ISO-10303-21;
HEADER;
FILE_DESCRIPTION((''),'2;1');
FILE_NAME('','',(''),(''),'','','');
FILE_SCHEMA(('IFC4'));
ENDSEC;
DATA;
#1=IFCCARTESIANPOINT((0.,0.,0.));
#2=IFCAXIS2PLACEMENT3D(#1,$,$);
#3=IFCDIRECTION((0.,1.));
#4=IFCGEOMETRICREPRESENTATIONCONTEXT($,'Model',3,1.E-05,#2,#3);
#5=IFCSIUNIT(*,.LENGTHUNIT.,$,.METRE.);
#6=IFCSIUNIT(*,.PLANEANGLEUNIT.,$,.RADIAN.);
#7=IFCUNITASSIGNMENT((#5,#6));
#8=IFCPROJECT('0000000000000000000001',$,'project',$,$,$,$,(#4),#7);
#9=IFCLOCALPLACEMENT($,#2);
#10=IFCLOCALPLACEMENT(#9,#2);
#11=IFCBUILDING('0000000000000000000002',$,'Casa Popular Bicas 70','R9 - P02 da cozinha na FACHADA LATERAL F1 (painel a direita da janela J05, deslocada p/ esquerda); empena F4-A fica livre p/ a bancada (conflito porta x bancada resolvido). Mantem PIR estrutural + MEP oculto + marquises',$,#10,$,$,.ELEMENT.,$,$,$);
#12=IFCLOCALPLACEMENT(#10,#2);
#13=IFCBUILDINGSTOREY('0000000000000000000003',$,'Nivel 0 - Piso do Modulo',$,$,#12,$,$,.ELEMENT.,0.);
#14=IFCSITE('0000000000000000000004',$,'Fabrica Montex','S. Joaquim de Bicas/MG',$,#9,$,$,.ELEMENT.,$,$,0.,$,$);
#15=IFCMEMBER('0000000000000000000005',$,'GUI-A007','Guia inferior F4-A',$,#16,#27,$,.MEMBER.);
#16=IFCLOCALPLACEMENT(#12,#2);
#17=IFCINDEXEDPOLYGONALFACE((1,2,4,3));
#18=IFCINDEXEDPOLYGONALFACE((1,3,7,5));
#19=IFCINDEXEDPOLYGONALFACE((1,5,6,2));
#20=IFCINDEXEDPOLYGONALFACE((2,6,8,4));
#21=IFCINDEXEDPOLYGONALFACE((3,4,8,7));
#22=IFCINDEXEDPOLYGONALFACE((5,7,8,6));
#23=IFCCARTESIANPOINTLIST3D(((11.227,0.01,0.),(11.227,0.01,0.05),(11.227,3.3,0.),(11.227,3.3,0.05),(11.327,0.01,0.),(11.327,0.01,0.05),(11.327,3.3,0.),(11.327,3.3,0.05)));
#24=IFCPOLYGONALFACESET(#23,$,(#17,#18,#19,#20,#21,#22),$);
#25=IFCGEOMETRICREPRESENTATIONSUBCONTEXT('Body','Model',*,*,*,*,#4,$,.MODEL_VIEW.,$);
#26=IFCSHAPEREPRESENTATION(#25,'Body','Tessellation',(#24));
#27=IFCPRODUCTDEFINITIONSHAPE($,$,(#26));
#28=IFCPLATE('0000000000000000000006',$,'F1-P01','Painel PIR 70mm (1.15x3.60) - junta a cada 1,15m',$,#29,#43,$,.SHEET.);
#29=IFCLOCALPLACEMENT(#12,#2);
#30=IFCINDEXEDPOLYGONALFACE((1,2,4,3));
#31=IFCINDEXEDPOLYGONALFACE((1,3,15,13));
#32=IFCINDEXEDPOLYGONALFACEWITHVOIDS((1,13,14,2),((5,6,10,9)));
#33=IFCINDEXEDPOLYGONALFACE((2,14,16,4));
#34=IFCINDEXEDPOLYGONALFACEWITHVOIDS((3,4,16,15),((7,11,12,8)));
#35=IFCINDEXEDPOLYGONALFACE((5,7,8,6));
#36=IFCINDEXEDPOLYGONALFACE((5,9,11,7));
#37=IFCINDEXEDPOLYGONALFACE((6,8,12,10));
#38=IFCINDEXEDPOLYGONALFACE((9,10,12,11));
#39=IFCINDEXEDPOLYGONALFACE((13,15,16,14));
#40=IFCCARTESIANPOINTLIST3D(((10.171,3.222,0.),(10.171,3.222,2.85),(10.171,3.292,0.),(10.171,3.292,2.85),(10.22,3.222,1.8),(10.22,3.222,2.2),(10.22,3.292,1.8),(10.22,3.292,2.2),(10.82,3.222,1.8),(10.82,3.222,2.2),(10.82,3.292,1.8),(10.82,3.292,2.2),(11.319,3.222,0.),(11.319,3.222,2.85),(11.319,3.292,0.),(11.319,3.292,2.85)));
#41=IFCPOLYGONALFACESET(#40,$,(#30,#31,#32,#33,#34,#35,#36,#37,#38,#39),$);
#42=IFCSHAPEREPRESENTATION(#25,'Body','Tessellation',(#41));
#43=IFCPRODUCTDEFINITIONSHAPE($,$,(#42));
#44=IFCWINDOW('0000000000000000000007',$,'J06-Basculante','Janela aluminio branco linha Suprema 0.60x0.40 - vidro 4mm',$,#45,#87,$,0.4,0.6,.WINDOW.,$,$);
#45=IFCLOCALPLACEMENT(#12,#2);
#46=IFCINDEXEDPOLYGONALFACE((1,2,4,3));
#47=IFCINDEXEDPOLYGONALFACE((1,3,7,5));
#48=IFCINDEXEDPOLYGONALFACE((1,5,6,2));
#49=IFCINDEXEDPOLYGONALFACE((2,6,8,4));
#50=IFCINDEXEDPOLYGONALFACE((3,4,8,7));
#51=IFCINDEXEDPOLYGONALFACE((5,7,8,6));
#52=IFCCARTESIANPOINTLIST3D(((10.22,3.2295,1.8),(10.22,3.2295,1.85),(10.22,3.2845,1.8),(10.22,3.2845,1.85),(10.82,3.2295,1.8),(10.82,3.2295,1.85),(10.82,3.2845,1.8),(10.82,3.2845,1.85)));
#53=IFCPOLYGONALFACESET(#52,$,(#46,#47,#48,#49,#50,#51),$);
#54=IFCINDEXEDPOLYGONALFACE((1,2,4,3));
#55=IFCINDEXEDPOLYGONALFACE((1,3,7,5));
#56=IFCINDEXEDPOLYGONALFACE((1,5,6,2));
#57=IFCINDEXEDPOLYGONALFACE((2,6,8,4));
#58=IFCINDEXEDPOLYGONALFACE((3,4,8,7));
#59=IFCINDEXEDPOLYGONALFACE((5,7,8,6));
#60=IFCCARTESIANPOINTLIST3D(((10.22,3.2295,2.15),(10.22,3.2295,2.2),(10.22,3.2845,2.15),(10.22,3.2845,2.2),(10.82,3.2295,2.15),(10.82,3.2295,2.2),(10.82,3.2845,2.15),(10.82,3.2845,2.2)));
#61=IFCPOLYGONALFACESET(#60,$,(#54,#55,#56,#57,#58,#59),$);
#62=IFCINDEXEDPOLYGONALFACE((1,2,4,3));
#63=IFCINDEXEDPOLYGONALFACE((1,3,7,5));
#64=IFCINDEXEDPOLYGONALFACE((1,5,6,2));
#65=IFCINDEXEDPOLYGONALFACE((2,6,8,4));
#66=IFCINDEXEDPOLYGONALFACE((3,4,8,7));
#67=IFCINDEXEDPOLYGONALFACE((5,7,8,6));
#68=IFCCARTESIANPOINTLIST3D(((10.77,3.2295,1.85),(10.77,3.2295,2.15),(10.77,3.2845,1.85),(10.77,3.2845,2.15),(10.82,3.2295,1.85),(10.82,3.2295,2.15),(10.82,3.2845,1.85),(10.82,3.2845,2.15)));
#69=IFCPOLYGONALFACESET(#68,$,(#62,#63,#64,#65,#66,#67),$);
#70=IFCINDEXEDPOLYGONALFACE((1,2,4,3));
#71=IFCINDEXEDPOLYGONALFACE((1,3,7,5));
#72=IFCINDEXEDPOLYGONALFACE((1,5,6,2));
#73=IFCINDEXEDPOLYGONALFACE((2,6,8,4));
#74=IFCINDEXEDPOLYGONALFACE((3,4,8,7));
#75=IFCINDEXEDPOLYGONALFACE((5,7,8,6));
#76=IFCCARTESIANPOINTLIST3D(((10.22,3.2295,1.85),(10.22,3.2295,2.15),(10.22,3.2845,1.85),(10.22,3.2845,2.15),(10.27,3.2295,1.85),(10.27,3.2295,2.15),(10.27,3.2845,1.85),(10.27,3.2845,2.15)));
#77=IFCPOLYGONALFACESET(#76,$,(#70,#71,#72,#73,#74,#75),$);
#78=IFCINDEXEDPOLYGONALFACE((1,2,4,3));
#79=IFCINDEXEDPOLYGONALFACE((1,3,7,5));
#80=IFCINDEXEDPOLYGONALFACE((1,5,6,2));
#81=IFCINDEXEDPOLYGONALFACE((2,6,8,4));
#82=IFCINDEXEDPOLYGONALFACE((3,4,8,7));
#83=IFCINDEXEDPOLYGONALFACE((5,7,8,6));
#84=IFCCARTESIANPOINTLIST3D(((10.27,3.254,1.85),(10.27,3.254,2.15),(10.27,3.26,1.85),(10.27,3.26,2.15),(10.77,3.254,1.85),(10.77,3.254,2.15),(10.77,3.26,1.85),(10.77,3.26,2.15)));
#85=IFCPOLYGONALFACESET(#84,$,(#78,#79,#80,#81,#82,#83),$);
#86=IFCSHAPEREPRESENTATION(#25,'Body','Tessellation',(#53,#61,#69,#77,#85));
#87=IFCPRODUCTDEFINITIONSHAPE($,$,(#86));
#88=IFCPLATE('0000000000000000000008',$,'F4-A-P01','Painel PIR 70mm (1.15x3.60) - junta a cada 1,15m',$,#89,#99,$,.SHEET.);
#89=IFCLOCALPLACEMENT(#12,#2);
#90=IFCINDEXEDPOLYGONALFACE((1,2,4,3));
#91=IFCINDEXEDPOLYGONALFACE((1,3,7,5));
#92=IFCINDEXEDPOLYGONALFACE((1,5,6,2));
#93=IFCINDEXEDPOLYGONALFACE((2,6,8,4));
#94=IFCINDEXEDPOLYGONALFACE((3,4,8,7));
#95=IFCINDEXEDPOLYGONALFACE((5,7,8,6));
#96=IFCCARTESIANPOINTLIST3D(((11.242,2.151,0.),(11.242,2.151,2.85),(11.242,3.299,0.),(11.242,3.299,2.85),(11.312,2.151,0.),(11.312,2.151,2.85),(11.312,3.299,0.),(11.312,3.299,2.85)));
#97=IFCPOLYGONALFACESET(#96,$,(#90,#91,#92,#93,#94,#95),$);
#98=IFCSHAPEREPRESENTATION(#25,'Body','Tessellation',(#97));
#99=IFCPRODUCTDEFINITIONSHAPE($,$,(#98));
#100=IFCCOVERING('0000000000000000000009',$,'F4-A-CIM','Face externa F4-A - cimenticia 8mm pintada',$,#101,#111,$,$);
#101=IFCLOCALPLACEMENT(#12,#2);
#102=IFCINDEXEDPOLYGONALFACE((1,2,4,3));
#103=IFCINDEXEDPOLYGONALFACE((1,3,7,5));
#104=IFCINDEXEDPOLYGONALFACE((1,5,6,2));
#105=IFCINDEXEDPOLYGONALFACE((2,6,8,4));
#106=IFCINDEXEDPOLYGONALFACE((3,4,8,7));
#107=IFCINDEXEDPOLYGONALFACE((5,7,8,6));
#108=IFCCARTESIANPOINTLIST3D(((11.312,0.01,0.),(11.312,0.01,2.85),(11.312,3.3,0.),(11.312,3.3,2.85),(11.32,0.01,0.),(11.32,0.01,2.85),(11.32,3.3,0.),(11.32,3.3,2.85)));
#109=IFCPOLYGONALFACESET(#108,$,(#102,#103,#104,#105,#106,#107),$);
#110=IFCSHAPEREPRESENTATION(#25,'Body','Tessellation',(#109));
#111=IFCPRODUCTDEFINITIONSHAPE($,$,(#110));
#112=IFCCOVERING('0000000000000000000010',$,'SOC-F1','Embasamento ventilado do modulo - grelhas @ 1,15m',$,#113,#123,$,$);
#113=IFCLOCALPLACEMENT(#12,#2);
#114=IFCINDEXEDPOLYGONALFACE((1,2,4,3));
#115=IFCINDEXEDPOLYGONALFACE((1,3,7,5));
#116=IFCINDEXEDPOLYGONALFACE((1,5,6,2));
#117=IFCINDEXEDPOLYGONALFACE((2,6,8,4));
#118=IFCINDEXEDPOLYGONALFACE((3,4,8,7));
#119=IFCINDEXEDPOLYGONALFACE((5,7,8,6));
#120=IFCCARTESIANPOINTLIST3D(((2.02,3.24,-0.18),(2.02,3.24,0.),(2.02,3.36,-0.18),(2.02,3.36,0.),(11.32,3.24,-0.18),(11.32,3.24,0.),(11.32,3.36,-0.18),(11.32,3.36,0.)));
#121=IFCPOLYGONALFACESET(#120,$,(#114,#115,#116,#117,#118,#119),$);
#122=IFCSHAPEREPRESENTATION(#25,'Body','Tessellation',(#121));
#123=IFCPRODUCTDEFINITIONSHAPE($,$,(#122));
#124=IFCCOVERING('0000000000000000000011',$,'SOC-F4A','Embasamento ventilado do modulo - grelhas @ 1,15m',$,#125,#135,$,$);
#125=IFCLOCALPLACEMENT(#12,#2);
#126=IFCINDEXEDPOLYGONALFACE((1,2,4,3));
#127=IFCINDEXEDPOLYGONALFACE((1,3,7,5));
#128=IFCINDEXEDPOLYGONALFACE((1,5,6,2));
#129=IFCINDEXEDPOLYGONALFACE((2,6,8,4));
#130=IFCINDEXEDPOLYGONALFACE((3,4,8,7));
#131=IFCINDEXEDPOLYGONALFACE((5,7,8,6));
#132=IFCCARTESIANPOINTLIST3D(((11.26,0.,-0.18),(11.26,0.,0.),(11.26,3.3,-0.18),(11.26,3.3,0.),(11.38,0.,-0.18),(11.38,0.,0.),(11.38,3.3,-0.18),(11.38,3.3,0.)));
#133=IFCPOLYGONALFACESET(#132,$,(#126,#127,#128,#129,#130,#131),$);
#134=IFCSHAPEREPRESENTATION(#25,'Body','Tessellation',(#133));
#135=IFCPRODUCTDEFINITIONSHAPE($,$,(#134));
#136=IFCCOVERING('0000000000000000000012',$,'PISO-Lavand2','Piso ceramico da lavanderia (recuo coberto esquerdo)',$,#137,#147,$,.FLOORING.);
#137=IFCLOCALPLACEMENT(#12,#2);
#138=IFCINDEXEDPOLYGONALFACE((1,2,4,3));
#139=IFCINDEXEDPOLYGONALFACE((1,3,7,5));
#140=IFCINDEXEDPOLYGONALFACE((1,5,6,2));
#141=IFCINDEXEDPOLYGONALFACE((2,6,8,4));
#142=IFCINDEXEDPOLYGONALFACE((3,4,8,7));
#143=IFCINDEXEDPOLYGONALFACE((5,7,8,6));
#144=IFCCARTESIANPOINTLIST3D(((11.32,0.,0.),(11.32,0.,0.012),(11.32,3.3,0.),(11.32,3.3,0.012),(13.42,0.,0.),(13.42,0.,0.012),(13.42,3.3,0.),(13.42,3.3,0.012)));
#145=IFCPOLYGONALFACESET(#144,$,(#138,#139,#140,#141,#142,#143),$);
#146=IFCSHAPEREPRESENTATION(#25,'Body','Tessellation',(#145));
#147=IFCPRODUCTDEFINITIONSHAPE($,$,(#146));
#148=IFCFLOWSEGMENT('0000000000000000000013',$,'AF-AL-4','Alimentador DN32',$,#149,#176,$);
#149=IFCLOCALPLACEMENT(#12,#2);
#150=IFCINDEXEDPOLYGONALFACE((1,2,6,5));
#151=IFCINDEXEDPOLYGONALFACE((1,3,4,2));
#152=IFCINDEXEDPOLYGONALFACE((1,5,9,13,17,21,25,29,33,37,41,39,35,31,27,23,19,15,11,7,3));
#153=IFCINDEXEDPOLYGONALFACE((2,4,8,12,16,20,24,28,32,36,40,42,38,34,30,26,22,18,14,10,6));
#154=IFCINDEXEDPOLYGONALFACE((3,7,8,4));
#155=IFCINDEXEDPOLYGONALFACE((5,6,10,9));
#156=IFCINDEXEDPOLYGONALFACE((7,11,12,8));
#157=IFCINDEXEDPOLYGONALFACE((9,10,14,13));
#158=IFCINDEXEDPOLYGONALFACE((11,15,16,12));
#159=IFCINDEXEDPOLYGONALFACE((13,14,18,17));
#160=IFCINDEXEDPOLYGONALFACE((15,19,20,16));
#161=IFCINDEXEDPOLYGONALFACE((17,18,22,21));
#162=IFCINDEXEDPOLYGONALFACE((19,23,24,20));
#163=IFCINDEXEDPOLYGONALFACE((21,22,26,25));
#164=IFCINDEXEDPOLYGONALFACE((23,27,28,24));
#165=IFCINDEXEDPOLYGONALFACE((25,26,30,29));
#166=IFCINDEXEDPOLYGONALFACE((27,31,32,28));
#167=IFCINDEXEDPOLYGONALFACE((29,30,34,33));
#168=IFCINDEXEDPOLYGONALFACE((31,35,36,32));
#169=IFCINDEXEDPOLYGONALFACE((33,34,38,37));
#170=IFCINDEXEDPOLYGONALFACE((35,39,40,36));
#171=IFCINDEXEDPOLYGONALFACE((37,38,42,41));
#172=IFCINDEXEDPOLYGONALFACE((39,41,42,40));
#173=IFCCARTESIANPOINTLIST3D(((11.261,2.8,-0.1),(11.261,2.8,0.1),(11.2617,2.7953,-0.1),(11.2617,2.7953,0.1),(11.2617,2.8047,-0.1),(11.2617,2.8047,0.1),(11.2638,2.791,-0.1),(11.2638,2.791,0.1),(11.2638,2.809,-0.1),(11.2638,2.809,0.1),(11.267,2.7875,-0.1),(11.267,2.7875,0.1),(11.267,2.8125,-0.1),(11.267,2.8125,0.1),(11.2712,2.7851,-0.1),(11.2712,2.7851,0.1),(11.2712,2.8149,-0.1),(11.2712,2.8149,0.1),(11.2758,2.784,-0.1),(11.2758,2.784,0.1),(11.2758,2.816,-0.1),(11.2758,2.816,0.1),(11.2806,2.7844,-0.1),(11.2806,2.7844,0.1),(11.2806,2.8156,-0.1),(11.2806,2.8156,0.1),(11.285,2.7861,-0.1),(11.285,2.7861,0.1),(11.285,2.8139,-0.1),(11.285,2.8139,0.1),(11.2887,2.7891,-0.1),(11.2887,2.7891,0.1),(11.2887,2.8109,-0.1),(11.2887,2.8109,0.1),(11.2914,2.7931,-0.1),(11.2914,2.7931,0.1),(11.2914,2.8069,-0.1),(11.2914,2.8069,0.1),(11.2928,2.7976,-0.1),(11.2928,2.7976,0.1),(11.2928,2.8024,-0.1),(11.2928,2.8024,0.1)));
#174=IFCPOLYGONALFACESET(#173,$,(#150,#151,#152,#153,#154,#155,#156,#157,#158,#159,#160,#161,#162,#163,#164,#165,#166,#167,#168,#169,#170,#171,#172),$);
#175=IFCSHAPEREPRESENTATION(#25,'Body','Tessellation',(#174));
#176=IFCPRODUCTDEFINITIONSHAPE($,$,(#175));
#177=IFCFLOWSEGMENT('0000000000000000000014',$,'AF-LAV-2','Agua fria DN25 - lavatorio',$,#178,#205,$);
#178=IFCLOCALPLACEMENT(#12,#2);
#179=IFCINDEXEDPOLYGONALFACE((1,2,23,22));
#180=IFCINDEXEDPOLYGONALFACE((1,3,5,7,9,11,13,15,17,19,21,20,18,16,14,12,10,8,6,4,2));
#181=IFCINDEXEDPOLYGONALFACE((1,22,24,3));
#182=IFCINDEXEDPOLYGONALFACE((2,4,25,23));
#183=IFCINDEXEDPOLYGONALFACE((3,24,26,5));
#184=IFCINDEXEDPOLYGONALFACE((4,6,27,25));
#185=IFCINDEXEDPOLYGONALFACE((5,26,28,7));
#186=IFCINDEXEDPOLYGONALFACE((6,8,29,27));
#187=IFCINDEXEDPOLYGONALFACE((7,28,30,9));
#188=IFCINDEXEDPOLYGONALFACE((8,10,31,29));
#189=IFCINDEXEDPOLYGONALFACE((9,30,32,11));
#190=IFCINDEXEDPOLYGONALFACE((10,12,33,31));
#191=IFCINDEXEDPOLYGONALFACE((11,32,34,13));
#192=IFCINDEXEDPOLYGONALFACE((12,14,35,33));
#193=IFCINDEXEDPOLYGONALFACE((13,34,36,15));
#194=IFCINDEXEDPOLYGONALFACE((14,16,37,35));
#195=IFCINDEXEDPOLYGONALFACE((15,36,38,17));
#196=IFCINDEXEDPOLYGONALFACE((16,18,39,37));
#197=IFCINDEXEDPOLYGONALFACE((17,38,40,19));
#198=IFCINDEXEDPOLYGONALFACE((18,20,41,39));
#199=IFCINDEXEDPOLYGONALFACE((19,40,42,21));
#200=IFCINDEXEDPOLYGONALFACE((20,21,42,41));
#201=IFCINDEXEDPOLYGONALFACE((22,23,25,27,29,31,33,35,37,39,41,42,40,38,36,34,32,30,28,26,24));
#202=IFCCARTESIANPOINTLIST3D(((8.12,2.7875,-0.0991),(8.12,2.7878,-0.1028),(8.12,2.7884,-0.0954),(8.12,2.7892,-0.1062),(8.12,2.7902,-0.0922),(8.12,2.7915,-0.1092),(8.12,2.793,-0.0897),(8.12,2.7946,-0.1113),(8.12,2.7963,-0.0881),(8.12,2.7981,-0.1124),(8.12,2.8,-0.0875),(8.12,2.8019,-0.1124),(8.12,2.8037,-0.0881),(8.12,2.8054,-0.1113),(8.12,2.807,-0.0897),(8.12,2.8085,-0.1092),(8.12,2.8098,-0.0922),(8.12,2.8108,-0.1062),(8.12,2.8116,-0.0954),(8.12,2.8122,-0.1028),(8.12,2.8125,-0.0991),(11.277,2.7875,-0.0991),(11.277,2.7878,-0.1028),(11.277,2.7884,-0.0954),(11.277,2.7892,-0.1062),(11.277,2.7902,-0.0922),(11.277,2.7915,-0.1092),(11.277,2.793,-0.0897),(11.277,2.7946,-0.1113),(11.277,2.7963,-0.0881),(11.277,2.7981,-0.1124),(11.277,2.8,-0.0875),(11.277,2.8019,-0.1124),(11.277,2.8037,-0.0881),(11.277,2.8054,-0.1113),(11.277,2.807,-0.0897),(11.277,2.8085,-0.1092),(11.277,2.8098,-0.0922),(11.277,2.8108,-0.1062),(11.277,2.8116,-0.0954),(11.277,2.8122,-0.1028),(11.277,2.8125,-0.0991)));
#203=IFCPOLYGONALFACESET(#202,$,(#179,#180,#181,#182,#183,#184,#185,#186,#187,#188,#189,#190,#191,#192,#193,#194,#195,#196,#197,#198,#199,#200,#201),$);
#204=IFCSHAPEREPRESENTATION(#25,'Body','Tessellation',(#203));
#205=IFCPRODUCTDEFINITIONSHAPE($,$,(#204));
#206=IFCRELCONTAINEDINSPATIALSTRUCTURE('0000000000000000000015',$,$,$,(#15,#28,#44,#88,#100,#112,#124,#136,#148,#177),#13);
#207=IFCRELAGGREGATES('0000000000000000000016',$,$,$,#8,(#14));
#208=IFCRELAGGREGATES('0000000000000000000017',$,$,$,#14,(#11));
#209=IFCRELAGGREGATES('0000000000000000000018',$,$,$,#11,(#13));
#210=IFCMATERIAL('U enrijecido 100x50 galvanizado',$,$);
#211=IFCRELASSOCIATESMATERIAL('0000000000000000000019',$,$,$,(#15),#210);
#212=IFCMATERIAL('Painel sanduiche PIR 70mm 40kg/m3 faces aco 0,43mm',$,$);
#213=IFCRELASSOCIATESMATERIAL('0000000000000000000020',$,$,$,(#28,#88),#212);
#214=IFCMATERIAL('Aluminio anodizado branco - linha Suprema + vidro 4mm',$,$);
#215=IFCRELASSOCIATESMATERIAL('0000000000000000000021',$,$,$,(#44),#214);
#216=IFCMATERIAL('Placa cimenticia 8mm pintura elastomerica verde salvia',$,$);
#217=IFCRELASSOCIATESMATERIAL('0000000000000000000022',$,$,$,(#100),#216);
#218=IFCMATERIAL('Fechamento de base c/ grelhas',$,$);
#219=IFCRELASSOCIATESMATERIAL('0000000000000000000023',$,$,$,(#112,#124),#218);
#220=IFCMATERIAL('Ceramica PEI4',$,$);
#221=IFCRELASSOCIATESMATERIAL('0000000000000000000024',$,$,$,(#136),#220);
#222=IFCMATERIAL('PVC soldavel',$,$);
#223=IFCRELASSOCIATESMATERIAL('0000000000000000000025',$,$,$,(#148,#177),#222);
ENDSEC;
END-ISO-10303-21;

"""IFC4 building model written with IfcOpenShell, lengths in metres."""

from ifc_helpers import new_model, si_unit, direction, frame, frame_2d, origin, origin_2d, place, context, subcontext, project, spatial, rectangle, circle, extrude, material, element, fill, save


model = new_model("IFC4")

# Units and contexts
model_context = context("Model", 3, precision=1e-05, world=origin(), true_north=direction((0.0, 1.0)))
body_context = subcontext(model_context, "Body", "Model", "MODEL_VIEW")
ifc_project = project(units=[si_unit("LENGTHUNIT", "METRE"), si_unit("PLANEANGLEUNIT", "RADIAN")], contexts=[model_context])

# Site, building, storey
site_placement = place(None, origin())
site = spatial("IfcSite", under=ifc_project, at=site_placement, Name="Fabrica Montex", Description="S. Joaquim de Bicas/MG", CompositionType="ELEMENT", RefElevation=0.0)
building_placement = place(site_placement, origin())
building = spatial("IfcBuilding", under=site, at=building_placement, Name="Casa Popular Bicas 70", Description="R9 - P02 da cozinha na FACHADA LATERAL F1 (painel a direita da janela J05, deslocada p/ esquerda); empena F4-A fica livre p/ a bancada (conflito porta x bancada resolvido). Mantem PIR estrutural + MEP oculto + marquises", CompositionType="ELEMENT")
storey_placement = place(building_placement, origin())
storey = spatial("IfcBuildingStorey", under=building, at=storey_placement, Name="Nivel 0 - Piso do Modulo", CompositionType="ELEMENT", Elevation=0.0)

# Member
ifc_material_1 = material(Name="U enrijecido 100x50 galvanizado")
member_placement = place(None, frame((11.277, 3.3, 0.025), z_axis=(0.0, -1.0, 0.0), x_axis=(0.0, 0.0, 1.0)))
element("IfcMember", 1, at=member_placement, inside=storey, material=ifc_material_1, Name="GUI-A007", Description="Guia inferior F4-A", PredefinedType="MEMBER", context=body_context, shape_type="SweptSolid", body=[
    extrude(rectangle(XDim=0.05, YDim=0.1, at=origin_2d()), origin(), (0.0, 0.0, 1.0), 3.29),
])

# Plate, opening, window
ifc_material_2 = material(Name="Painel sanduiche PIR 70mm 40kg/m3 faces aco 0,43mm")
plate_1_placement = place(None, frame((11.319, 3.257, 0.0), z_axis=(0.0, 0.0, 1.0), x_axis=(-1.0, 0.0, 0.0)))
plate_1 = element("IfcPlate", 2, at=plate_1_placement, inside=storey, material=ifc_material_2, Name="F1-P01", Description="Painel PIR 70mm (1.15x3.60) - junta a cada 1,15m", PredefinedType="SHEET", context=body_context, shape_type="SweptSolid", body=[
    extrude(rectangle(XDim=1.148, YDim=0.07, at=frame_2d((0.574, 0.0))), origin(), (0.0, 0.0, 1.0), 2.85),
])
opening_1_placement = place(None, frame((10.52, 3.257, 1.8), z_axis=(0.0, 0.0, 1.0), x_axis=(-1.0, 0.0, 0.0)))
opening_1 = element("IfcOpeningElement", 3, at=opening_1_placement, cuts=plate_1, PredefinedType="OPENING", context=body_context, shape_type="SweptSolid", body=[
    extrude(rectangle(XDim=0.6, YDim=0.1, at=origin_2d()), origin(), (0.0, 0.0, 1.0), 0.4),
])
ifc_material_3 = material(Name="Aluminio anodizado branco - linha Suprema + vidro 4mm")
window_placement = place(None, frame((10.82, 3.257, 1.8), z_axis=(0.0, 0.0, 1.0), x_axis=(-1.0, 0.0, 0.0)))
window = element("IfcWindow", 4, at=window_placement, inside=storey, material=ifc_material_3, Name="J06-Basculante", Description="Janela aluminio branco linha Suprema 0.60x0.40 - vidro 4mm", OverallHeight=0.4, OverallWidth=0.6, PredefinedType="WINDOW", context=body_context, shape_type="SweptSolid", body=[
    extrude(rectangle(XDim=0.6, YDim=0.055, at=frame_2d((0.3, 0.0))), origin(), (0.0, 0.0, 1.0), 0.05),
    extrude(rectangle(XDim=0.6, YDim=0.055, at=frame_2d((0.3, 0.0))), frame((0.0, 0.0, 0.35)), (0.0, 0.0, 1.0), 0.05),
    extrude(rectangle(XDim=0.05, YDim=0.055, at=frame_2d((0.025, 0.0))), frame((0.0, 0.0, 0.05)), (0.0, 0.0, 1.0), 0.3),
    extrude(rectangle(XDim=0.05, YDim=0.055, at=frame_2d((0.575, 0.0))), frame((0.0, 0.0, 0.05)), (0.0, 0.0, 1.0), 0.3),
    extrude(rectangle(XDim=0.5, YDim=0.006, at=frame_2d((0.3, 0.0))), frame((0.0, 0.0, 0.05)), (0.0, 0.0, 1.0), 0.3),
])
fill(opening_1, window)

# Plate
plate_2_placement = place(None, frame((11.277, 3.299, 0.0), z_axis=(0.0, 0.0, 1.0), x_axis=(0.0, -1.0, 0.0)))
element("IfcPlate", 5, at=plate_2_placement, inside=storey, material=ifc_material_2, Name="F4-A-P01", Description="Painel PIR 70mm (1.15x3.60) - junta a cada 1,15m", PredefinedType="SHEET", context=body_context, shape_type="SweptSolid", body=[
    extrude(rectangle(XDim=1.148, YDim=0.07, at=frame_2d((0.574, 0.0))), origin(), (0.0, 0.0, 1.0), 2.85),
])

# Shared definitions
ifc_material_4 = material(Name="Placa cimenticia 8mm pintura elastomerica verde salvia")

# Coverings
covering_1_placement = place(None, frame((11.316, 3.3, 0.0), z_axis=(0.0, 0.0, 1.0), x_axis=(0.0, -1.0, 0.0)))
element("IfcCovering", 6, at=covering_1_placement, inside=storey, material=ifc_material_4, Name="F4-A-CIM", Description="Face externa F4-A - cimenticia 8mm pintada", context=body_context, shape_type="SweptSolid", body=[
    extrude(rectangle(XDim=3.29, YDim=0.008, at=frame_2d((1.645, 0.0))), origin(), (0.0, 0.0, 1.0), 2.85),
])
ifc_material_5 = material(Name="Fechamento de base c/ grelhas")
covering_2_placement = place(None, frame((11.32, 3.3, -0.18), z_axis=(0.0, 0.0, 1.0), x_axis=(-1.0, 0.0, 0.0)))
element("IfcCovering", 7, at=covering_2_placement, inside=storey, material=ifc_material_5, Name="SOC-F1", Description="Embasamento ventilado do modulo - grelhas @ 1,15m", context=body_context, shape_type="SweptSolid", body=[
    extrude(rectangle(XDim=9.3, YDim=0.12, at=frame_2d((4.65, 0.0))), origin(), (0.0, 0.0, 1.0), 0.18),
])
covering_3_placement = place(None, frame((11.32, 3.3, -0.18), z_axis=(0.0, 0.0, 1.0), x_axis=(0.0, -1.0, 0.0)))
element("IfcCovering", 8, at=covering_3_placement, inside=storey, material=ifc_material_5, Name="SOC-F4A", Description="Embasamento ventilado do modulo - grelhas @ 1,15m", context=body_context, shape_type="SweptSolid", body=[
    extrude(rectangle(XDim=3.3, YDim=0.12, at=frame_2d((1.65, 0.0))), origin(), (0.0, 0.0, 1.0), 0.18),
])
ifc_material_6 = material(Name="Ceramica PEI4")
covering_4_placement = place(None, frame((13.42, 3.3, 0.0), z_axis=(0.0, 0.0, 1.0), x_axis=(-1.0, 0.0, 0.0)))
element("IfcCovering", 9, at=covering_4_placement, inside=storey, material=ifc_material_6, Name="PISO-Lavand2", Description="Piso ceramico da lavanderia (recuo coberto esquerdo)", PredefinedType="FLOORING", context=body_context, shape_type="SweptSolid", body=[
    extrude(rectangle(XDim=2.1, YDim=3.3, at=frame_2d((1.05, 1.65))), origin(), (0.0, 0.0, 1.0), 0.012),
])

# Flow segments
ifc_material_7 = material(Name="PVC soldavel")
flow_segment_1_placement = place(None, frame((11.277, 2.8, -0.1), z_axis=(0.0, 0.0, 1.0), x_axis=(-1.0, 0.0, 0.0)))
element("IfcFlowSegment", 10, at=flow_segment_1_placement, inside=storey, material=ifc_material_7, Name="AF-AL-4", Description="Alimentador DN32", context=body_context, shape_type="SweptSolid", body=[
    extrude(circle(Radius=0.016, at=origin_2d()), origin(), (0.0, 0.0, 1.0), 0.2),
])
flow_segment_2_placement = place(None, frame((11.277, 2.8, -0.1), z_axis=(-1.0, 0.0, 0.0), x_axis=(0.0, 0.0, 1.0)))
element("IfcFlowSegment", 11, at=flow_segment_2_placement, inside=storey, material=ifc_material_7, Name="AF-LAV-2", Description="Agua fria DN25 - lavatorio", context=body_context, shape_type="SweptSolid", body=[
    extrude(circle(Radius=0.0125, at=origin_2d()), origin(), (0.0, 0.0, 1.0), 3.157),
])

save(model, "model.ifc")
